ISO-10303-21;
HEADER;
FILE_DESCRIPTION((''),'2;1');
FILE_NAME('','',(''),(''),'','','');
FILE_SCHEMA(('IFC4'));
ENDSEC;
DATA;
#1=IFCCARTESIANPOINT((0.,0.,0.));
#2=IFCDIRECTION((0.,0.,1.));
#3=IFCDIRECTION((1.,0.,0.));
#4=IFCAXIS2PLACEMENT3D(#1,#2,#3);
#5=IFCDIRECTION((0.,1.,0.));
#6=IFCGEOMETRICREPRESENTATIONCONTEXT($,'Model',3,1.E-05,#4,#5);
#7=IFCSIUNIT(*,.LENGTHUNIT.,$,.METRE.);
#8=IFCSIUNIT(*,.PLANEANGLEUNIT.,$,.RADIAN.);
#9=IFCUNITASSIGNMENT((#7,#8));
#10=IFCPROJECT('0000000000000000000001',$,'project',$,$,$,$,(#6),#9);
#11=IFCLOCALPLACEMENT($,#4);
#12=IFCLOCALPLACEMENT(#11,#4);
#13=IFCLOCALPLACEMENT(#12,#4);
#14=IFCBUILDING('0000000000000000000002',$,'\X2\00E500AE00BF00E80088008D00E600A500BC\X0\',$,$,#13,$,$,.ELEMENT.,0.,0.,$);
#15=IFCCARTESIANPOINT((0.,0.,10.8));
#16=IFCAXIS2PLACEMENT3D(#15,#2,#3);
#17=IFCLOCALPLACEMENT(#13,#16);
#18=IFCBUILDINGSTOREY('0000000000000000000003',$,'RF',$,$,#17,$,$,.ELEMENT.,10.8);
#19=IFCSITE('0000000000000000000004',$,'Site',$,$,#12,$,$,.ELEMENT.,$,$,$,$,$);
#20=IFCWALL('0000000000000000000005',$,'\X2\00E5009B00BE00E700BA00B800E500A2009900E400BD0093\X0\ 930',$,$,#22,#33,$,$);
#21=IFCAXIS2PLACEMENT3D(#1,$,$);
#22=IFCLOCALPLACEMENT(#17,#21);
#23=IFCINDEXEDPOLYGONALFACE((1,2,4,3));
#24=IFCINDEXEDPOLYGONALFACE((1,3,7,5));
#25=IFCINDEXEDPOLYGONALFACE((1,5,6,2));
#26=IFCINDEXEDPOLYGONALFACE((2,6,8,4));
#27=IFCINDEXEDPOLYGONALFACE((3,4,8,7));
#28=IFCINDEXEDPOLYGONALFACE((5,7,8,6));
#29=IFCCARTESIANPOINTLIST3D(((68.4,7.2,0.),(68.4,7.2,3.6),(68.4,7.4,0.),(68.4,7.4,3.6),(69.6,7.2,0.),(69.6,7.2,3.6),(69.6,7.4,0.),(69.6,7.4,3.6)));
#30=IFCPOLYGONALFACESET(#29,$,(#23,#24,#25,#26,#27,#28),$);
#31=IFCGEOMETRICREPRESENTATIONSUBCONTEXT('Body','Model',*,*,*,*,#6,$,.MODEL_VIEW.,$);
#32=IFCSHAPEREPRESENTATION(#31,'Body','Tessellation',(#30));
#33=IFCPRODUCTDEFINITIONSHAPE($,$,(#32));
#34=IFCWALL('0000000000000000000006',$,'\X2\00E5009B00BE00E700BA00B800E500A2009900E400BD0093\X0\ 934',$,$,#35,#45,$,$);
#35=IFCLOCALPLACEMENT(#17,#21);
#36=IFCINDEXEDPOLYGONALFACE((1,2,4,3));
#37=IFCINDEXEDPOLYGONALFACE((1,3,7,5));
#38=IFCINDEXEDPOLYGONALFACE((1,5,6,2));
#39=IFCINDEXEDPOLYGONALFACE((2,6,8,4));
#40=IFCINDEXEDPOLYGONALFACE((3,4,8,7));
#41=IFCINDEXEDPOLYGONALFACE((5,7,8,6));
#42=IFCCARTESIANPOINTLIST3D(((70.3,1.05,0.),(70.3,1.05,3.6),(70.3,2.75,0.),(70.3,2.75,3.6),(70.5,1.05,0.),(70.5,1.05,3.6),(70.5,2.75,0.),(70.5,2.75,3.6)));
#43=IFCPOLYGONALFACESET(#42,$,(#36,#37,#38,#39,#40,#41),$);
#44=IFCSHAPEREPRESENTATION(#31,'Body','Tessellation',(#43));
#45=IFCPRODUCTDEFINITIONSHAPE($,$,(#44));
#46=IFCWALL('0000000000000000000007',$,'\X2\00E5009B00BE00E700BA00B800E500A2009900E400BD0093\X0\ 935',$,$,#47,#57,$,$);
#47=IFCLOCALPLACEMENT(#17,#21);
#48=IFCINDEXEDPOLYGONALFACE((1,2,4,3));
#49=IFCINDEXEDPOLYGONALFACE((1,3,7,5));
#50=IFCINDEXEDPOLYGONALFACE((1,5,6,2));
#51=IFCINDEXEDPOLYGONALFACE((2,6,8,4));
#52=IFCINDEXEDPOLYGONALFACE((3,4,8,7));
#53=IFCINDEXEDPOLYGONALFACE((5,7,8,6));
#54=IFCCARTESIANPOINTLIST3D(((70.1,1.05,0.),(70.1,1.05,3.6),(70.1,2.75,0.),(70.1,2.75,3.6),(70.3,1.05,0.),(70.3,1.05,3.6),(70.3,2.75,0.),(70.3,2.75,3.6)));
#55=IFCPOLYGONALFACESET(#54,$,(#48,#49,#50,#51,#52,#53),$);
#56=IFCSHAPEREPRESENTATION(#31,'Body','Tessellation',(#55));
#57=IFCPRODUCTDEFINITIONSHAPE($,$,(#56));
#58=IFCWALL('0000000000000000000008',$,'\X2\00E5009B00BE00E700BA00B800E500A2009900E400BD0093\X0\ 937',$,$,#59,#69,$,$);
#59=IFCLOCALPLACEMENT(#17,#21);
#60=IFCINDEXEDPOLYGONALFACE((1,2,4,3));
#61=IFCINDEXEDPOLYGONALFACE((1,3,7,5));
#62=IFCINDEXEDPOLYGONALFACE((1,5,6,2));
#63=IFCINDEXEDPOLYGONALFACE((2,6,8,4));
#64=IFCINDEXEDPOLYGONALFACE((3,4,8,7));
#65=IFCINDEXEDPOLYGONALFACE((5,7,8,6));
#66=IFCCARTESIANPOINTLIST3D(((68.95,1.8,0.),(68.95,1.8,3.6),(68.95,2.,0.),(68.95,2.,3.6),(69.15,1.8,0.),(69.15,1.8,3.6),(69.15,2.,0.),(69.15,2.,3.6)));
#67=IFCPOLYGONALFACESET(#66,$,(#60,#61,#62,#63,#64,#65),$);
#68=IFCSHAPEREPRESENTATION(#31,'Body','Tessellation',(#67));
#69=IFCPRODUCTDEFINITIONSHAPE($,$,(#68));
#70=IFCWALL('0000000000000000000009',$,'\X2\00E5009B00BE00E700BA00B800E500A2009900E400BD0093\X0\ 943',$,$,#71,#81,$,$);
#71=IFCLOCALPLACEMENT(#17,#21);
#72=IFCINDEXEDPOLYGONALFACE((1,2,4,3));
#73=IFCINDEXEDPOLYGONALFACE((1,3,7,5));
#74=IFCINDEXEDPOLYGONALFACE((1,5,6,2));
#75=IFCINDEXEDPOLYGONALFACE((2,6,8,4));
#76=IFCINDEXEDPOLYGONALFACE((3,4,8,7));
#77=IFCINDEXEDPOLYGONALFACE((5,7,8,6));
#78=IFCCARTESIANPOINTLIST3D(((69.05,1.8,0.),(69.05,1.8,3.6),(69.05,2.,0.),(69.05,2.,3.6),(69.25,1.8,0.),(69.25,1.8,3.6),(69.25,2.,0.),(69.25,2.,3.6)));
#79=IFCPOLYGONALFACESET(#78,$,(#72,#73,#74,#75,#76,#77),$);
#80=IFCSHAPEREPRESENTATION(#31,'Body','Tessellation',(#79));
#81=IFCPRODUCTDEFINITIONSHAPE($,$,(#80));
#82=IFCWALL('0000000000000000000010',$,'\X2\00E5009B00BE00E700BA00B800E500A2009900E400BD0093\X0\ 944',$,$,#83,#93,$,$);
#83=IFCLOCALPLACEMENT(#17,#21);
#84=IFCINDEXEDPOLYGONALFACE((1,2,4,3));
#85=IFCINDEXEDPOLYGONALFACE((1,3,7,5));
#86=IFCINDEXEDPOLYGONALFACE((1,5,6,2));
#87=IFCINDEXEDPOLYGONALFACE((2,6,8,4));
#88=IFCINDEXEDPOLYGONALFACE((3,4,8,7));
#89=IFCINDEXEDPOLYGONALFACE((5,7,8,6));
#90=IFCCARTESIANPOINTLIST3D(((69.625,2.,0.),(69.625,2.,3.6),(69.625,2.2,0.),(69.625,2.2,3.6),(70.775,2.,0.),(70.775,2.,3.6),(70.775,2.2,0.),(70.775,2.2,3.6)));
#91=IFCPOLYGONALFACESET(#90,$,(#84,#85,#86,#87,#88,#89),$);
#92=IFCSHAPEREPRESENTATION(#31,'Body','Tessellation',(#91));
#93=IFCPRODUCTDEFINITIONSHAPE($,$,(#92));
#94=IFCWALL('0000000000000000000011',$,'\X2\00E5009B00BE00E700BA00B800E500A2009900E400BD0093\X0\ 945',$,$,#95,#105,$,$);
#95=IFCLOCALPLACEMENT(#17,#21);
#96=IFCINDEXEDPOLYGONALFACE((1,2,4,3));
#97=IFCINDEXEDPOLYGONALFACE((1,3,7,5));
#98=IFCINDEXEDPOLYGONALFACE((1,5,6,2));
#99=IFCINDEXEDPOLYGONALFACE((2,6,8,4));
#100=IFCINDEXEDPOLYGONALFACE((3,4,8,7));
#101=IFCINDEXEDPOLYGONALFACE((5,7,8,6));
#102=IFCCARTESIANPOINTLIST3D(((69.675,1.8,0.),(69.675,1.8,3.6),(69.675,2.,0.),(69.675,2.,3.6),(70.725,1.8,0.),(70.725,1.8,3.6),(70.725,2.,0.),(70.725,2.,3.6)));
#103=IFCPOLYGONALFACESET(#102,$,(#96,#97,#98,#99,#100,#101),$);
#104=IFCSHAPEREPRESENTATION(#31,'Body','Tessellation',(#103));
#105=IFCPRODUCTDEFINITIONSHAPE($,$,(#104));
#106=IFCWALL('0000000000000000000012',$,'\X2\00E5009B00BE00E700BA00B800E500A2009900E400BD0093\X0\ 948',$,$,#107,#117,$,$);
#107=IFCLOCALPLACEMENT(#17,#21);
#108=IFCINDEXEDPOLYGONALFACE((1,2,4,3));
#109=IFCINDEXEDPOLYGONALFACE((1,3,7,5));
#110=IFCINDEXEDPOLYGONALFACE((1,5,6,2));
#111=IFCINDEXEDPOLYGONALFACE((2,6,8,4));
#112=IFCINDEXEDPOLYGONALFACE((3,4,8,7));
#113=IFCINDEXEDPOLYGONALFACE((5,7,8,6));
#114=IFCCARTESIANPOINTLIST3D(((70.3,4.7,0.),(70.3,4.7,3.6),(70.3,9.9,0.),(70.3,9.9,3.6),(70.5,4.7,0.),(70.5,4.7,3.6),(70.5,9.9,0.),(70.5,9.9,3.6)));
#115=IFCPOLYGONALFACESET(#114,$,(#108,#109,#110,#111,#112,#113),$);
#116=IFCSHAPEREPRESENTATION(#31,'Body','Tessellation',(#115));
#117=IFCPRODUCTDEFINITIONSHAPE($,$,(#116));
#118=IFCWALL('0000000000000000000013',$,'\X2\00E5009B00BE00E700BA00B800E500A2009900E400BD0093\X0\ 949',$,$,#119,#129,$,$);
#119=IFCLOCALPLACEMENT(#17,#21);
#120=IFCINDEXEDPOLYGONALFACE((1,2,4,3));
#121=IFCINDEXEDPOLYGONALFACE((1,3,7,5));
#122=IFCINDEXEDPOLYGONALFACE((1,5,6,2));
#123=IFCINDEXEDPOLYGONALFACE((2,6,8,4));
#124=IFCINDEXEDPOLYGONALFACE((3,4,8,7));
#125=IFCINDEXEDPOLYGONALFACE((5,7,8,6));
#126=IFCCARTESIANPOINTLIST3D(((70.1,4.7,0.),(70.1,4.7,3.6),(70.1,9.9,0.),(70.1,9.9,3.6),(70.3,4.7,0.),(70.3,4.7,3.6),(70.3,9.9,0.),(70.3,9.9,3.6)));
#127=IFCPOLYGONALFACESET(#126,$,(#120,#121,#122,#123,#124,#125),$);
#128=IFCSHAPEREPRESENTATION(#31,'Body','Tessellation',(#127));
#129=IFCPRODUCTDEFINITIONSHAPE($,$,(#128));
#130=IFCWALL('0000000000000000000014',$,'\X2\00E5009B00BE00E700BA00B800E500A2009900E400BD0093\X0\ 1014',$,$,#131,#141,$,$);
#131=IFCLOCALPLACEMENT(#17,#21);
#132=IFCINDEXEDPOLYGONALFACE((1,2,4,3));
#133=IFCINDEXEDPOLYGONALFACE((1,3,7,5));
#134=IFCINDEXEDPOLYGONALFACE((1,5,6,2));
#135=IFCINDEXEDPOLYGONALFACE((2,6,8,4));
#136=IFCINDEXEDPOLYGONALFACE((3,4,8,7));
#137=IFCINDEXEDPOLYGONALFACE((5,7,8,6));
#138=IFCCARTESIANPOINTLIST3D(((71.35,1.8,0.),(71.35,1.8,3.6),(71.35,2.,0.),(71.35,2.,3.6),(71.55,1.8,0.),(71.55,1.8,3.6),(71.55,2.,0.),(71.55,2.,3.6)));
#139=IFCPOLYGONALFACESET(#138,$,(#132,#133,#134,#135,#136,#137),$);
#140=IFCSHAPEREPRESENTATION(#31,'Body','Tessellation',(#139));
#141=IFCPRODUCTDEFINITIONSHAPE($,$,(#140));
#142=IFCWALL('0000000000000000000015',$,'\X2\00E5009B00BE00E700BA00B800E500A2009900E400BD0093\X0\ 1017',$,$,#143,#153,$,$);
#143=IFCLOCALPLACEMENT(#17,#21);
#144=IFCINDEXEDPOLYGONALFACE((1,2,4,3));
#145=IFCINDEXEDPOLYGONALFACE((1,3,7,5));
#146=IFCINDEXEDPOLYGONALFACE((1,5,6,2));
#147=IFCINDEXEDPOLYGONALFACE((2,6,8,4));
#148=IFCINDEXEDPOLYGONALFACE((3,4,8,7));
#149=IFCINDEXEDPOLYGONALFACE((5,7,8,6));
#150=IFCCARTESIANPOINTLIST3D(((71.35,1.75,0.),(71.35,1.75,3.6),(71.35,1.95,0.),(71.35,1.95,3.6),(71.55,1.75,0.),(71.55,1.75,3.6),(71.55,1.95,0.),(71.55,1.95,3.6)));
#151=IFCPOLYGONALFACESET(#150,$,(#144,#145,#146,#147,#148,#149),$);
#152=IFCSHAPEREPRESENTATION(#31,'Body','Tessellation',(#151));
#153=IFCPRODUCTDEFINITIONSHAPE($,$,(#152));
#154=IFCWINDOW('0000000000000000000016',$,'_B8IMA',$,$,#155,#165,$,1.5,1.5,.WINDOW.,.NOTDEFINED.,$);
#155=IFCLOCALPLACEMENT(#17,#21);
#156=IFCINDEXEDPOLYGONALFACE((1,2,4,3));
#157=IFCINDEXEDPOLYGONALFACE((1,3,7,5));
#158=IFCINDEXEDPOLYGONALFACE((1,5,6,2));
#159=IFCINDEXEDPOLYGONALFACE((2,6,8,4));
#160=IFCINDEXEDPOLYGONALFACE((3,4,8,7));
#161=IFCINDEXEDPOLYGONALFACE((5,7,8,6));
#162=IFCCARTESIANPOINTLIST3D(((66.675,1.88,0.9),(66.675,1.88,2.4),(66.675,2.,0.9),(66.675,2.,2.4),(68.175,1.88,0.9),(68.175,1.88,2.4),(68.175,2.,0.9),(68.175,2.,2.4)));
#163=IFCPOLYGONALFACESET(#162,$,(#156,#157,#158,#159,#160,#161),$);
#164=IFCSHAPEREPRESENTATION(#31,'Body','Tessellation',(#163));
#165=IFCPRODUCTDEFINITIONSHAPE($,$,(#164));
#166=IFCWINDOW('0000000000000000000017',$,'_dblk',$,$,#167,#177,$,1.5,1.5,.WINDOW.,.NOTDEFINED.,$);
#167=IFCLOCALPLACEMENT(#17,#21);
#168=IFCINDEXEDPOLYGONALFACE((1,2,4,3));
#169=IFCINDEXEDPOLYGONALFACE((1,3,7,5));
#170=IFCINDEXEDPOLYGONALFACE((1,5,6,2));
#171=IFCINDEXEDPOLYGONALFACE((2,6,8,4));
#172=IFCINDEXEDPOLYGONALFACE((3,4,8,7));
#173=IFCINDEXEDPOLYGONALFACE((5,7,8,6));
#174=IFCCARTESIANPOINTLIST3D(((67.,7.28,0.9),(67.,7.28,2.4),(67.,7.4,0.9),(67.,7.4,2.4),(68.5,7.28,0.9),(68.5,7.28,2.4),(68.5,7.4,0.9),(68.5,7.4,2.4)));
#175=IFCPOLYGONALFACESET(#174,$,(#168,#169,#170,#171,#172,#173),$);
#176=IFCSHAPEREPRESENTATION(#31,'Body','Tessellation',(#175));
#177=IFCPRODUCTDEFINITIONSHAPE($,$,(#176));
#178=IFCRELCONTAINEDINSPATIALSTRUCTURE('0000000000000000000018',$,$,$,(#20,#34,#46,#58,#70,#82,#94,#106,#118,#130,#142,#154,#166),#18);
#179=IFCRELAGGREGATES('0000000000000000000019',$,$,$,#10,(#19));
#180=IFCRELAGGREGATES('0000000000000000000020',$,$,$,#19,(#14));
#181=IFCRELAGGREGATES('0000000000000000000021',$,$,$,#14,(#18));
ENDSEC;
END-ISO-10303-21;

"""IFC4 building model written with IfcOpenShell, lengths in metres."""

from ifc_helpers import new_model, si_unit, direction, frame, frame_2d, origin_with_axes, place, context, subcontext, project, spatial, rectangle, extrude, element, save


model = new_model("IFC4")

# Units and contexts
model_context = context("Model", 3, precision=1e-05, world=origin_with_axes(), true_north=direction((0.0, 1.0, 0.0)))
body_context = subcontext(model_context, "Body", "Model", "MODEL_VIEW")
ifc_project = project(units=[si_unit("LENGTHUNIT", "METRE"), si_unit("PLANEANGLEUNIT", "RADIAN")], contexts=[model_context])

# Site, building, storey
placement = place(None, origin_with_axes())
site_placement = place(placement, origin_with_axes())
site = spatial("IfcSite", under=ifc_project, at=site_placement, Name="Site", CompositionType="ELEMENT")
building_placement = place(site_placement, origin_with_axes())
building = spatial("IfcBuilding", under=site, at=building_placement, Name="å®¿è\u0088\u008dæ¥¼", CompositionType="ELEMENT", ElevationOfRefHeight=0.0, ElevationOfTerrain=0.0)
storey_placement = place(building_placement, frame((0.0, 0.0, 10.8), z_axis=(0.0, 0.0, 1.0), x_axis=(1.0, 0.0, 0.0)))
storey = spatial("IfcBuildingStorey", under=building, at=storey_placement, Name="RF", CompositionType="ELEMENT", Elevation=10.8)

# Walls
wall_1_placement = place(storey_placement, frame((69.0, 7.3, 0.0), z_axis=(0.0, 0.0, 1.0), x_axis=(1.0, 0.0, 0.0)))
element("IfcWall", 1, at=wall_1_placement, inside=storey, Name="å\u009b¾çº¸å¢\u0099ä½\u0093 930", context=body_context, shape_type="SweptSolid", body=[
    extrude(rectangle(XDim=1.2, YDim=0.2, at=frame_2d((0.0, 0.0), x_axis=(1.0, 0.0, 0.0))), frame((0.0, 0.0, 0.0), z_axis=(0.0, 0.0, 1.0)), (0.0, 0.0, 1.0), 3.6),
])
for number, where, z_axis, x_axis, name in (
    (2, (70.4, 1.9, 0.0), (0.0, 0.0, 1.0), (0.0, -1.0, 0.0), "å\u009b¾çº¸å¢\u0099ä½\u0093 934"),
    (3, (70.2, 1.9, 0.0), (0.0, 0.0, 1.0), (0.0, -1.0, 0.0), "å\u009b¾çº¸å¢\u0099ä½\u0093 935"),
):
    element("IfcWall", number, at=place(storey_placement, frame(where, z_axis=z_axis, x_axis=x_axis)), inside=storey, Name=name, context=body_context, shape_type="SweptSolid", body=[
        extrude(rectangle(XDim=1.7, YDim=0.2, at=frame_2d((0.0, 0.0), x_axis=(1.0, 0.0, 0.0))), frame((0.0, 0.0, 0.0), z_axis=(0.0, 0.0, 1.0)), (0.0, 0.0, 1.0), 3.6),
    ])
for number, where, z_axis, x_axis, name in (
    (4, (69.05, 1.9, 0.0), (0.0, 0.0, 1.0), (0.0, 1.0, 0.0), "å\u009b¾çº¸å¢\u0099ä½\u0093 937"),
    (5, (69.15, 1.9, 0.0), (0.0, 0.0, 1.0), (0.0, -1.0, 0.0), "å\u009b¾çº¸å¢\u0099ä½\u0093 943"),
):
    element("IfcWall", number, at=place(storey_placement, frame(where, z_axis=z_axis, x_axis=x_axis)), inside=storey, Name=name, context=body_context, shape_type="SweptSolid", body=[
        extrude(rectangle(XDim=0.2, YDim=0.2, at=frame_2d((0.0, 0.0), x_axis=(1.0, 0.0, 0.0))), frame((0.0, 0.0, 0.0), z_axis=(0.0, 0.0, 1.0)), (0.0, 0.0, 1.0), 3.6),
    ])
wall_2_placement = place(storey_placement, frame((70.2, 2.1, 0.0), z_axis=(0.0, 0.0, 1.0), x_axis=(-1.0, 0.0, 0.0)))
element("IfcWall", 6, at=wall_2_placement, inside=storey, Name="å\u009b¾çº¸å¢\u0099ä½\u0093 944", context=body_context, shape_type="SweptSolid", body=[
    extrude(rectangle(XDim=1.15, YDim=0.2, at=frame_2d((0.0, 0.0), x_axis=(1.0, 0.0, 0.0))), frame((0.0, 0.0, 0.0), z_axis=(0.0, 0.0, 1.0)), (0.0, 0.0, 1.0), 3.6),
])
wall_3_placement = place(storey_placement, frame((70.2, 1.9, 0.0), z_axis=(0.0, 0.0, 1.0), x_axis=(-1.0, 0.0, 0.0)))
element("IfcWall", 7, at=wall_3_placement, inside=storey, Name="å\u009b¾çº¸å¢\u0099ä½\u0093 945", context=body_context, shape_type="SweptSolid", body=[
    extrude(rectangle(XDim=1.05, YDim=0.2, at=frame_2d((0.0, 0.0), x_axis=(1.0, 0.0, 0.0))), frame((0.0, 0.0, 0.0), z_axis=(0.0, 0.0, 1.0)), (0.0, 0.0, 1.0), 3.6),
])
for number, where, z_axis, x_axis, name in (
    (8, (70.4, 7.3, 0.0), (0.0, 0.0, 1.0), (0.0, -1.0, 0.0), "å\u009b¾çº¸å¢\u0099ä½\u0093 948"),
    (9, (70.2, 7.3, 0.0), (0.0, 0.0, 1.0), (0.0, -1.0, 0.0), "å\u009b¾çº¸å¢\u0099ä½\u0093 949"),
):
    element("IfcWall", number, at=place(storey_placement, frame(where, z_axis=z_axis, x_axis=x_axis)), inside=storey, Name=name, context=body_context, shape_type="SweptSolid", body=[
        extrude(rectangle(XDim=5.2, YDim=0.2, at=frame_2d((0.0, 0.0), x_axis=(1.0, 0.0, 0.0))), frame((0.0, 0.0, 0.0), z_axis=(0.0, 0.0, 1.0)), (0.0, 0.0, 1.0), 3.6),
    ])
for number, where, z_axis, x_axis, name in (
    (10, (71.45, 1.9, 0.0), (0.0, 0.0, 1.0), (0.0, -1.0, 0.0), "å\u009b¾çº¸å¢\u0099ä½\u0093 1014"),
    (11, (71.45, 1.85, 0.0), (0.0, 0.0, 1.0), (1.0, 0.0, 0.0), "å\u009b¾çº¸å¢\u0099ä½\u0093 1017"),
):
    element("IfcWall", number, at=place(storey_placement, frame(where, z_axis=z_axis, x_axis=x_axis)), inside=storey, Name=name, context=body_context, shape_type="SweptSolid", body=[
        extrude(rectangle(XDim=0.2, YDim=0.2, at=frame_2d((0.0, 0.0), x_axis=(1.0, 0.0, 0.0))), frame((0.0, 0.0, 0.0), z_axis=(0.0, 0.0, 1.0)), (0.0, 0.0, 1.0), 3.6),
    ])

# Windows
for number, where, z_axis, x_axis, name in (
    (12, (67.425, 1.94, 0.9), (0.0, 0.0, 1.0), (1.0, 0.0, 0.0), "_B8IMA"),
    (13, (67.75, 7.34, 0.9), (0.0, 0.0, 1.0), (1.0, 0.0, 0.0), "_dblk"),
):
    element("IfcWindow", number, at=place(storey_placement, frame(where, z_axis=z_axis, x_axis=x_axis)), inside=storey, Name=name, OverallHeight=1.5, OverallWidth=1.5, PartitioningType="NOTDEFINED", PredefinedType="WINDOW", context=body_context, shape_type="SweptSolid", body=[
        extrude(rectangle(XDim=1.5, YDim=0.12, at=frame_2d((0.0, 0.0), x_axis=(1.0, 0.0, 0.0))), frame((0.0, 0.0, 0.0), z_axis=(0.0, 0.0, 1.0)), (0.0, 0.0, 1.0), 1.5),
    ])

save(model, "model.ifc")
